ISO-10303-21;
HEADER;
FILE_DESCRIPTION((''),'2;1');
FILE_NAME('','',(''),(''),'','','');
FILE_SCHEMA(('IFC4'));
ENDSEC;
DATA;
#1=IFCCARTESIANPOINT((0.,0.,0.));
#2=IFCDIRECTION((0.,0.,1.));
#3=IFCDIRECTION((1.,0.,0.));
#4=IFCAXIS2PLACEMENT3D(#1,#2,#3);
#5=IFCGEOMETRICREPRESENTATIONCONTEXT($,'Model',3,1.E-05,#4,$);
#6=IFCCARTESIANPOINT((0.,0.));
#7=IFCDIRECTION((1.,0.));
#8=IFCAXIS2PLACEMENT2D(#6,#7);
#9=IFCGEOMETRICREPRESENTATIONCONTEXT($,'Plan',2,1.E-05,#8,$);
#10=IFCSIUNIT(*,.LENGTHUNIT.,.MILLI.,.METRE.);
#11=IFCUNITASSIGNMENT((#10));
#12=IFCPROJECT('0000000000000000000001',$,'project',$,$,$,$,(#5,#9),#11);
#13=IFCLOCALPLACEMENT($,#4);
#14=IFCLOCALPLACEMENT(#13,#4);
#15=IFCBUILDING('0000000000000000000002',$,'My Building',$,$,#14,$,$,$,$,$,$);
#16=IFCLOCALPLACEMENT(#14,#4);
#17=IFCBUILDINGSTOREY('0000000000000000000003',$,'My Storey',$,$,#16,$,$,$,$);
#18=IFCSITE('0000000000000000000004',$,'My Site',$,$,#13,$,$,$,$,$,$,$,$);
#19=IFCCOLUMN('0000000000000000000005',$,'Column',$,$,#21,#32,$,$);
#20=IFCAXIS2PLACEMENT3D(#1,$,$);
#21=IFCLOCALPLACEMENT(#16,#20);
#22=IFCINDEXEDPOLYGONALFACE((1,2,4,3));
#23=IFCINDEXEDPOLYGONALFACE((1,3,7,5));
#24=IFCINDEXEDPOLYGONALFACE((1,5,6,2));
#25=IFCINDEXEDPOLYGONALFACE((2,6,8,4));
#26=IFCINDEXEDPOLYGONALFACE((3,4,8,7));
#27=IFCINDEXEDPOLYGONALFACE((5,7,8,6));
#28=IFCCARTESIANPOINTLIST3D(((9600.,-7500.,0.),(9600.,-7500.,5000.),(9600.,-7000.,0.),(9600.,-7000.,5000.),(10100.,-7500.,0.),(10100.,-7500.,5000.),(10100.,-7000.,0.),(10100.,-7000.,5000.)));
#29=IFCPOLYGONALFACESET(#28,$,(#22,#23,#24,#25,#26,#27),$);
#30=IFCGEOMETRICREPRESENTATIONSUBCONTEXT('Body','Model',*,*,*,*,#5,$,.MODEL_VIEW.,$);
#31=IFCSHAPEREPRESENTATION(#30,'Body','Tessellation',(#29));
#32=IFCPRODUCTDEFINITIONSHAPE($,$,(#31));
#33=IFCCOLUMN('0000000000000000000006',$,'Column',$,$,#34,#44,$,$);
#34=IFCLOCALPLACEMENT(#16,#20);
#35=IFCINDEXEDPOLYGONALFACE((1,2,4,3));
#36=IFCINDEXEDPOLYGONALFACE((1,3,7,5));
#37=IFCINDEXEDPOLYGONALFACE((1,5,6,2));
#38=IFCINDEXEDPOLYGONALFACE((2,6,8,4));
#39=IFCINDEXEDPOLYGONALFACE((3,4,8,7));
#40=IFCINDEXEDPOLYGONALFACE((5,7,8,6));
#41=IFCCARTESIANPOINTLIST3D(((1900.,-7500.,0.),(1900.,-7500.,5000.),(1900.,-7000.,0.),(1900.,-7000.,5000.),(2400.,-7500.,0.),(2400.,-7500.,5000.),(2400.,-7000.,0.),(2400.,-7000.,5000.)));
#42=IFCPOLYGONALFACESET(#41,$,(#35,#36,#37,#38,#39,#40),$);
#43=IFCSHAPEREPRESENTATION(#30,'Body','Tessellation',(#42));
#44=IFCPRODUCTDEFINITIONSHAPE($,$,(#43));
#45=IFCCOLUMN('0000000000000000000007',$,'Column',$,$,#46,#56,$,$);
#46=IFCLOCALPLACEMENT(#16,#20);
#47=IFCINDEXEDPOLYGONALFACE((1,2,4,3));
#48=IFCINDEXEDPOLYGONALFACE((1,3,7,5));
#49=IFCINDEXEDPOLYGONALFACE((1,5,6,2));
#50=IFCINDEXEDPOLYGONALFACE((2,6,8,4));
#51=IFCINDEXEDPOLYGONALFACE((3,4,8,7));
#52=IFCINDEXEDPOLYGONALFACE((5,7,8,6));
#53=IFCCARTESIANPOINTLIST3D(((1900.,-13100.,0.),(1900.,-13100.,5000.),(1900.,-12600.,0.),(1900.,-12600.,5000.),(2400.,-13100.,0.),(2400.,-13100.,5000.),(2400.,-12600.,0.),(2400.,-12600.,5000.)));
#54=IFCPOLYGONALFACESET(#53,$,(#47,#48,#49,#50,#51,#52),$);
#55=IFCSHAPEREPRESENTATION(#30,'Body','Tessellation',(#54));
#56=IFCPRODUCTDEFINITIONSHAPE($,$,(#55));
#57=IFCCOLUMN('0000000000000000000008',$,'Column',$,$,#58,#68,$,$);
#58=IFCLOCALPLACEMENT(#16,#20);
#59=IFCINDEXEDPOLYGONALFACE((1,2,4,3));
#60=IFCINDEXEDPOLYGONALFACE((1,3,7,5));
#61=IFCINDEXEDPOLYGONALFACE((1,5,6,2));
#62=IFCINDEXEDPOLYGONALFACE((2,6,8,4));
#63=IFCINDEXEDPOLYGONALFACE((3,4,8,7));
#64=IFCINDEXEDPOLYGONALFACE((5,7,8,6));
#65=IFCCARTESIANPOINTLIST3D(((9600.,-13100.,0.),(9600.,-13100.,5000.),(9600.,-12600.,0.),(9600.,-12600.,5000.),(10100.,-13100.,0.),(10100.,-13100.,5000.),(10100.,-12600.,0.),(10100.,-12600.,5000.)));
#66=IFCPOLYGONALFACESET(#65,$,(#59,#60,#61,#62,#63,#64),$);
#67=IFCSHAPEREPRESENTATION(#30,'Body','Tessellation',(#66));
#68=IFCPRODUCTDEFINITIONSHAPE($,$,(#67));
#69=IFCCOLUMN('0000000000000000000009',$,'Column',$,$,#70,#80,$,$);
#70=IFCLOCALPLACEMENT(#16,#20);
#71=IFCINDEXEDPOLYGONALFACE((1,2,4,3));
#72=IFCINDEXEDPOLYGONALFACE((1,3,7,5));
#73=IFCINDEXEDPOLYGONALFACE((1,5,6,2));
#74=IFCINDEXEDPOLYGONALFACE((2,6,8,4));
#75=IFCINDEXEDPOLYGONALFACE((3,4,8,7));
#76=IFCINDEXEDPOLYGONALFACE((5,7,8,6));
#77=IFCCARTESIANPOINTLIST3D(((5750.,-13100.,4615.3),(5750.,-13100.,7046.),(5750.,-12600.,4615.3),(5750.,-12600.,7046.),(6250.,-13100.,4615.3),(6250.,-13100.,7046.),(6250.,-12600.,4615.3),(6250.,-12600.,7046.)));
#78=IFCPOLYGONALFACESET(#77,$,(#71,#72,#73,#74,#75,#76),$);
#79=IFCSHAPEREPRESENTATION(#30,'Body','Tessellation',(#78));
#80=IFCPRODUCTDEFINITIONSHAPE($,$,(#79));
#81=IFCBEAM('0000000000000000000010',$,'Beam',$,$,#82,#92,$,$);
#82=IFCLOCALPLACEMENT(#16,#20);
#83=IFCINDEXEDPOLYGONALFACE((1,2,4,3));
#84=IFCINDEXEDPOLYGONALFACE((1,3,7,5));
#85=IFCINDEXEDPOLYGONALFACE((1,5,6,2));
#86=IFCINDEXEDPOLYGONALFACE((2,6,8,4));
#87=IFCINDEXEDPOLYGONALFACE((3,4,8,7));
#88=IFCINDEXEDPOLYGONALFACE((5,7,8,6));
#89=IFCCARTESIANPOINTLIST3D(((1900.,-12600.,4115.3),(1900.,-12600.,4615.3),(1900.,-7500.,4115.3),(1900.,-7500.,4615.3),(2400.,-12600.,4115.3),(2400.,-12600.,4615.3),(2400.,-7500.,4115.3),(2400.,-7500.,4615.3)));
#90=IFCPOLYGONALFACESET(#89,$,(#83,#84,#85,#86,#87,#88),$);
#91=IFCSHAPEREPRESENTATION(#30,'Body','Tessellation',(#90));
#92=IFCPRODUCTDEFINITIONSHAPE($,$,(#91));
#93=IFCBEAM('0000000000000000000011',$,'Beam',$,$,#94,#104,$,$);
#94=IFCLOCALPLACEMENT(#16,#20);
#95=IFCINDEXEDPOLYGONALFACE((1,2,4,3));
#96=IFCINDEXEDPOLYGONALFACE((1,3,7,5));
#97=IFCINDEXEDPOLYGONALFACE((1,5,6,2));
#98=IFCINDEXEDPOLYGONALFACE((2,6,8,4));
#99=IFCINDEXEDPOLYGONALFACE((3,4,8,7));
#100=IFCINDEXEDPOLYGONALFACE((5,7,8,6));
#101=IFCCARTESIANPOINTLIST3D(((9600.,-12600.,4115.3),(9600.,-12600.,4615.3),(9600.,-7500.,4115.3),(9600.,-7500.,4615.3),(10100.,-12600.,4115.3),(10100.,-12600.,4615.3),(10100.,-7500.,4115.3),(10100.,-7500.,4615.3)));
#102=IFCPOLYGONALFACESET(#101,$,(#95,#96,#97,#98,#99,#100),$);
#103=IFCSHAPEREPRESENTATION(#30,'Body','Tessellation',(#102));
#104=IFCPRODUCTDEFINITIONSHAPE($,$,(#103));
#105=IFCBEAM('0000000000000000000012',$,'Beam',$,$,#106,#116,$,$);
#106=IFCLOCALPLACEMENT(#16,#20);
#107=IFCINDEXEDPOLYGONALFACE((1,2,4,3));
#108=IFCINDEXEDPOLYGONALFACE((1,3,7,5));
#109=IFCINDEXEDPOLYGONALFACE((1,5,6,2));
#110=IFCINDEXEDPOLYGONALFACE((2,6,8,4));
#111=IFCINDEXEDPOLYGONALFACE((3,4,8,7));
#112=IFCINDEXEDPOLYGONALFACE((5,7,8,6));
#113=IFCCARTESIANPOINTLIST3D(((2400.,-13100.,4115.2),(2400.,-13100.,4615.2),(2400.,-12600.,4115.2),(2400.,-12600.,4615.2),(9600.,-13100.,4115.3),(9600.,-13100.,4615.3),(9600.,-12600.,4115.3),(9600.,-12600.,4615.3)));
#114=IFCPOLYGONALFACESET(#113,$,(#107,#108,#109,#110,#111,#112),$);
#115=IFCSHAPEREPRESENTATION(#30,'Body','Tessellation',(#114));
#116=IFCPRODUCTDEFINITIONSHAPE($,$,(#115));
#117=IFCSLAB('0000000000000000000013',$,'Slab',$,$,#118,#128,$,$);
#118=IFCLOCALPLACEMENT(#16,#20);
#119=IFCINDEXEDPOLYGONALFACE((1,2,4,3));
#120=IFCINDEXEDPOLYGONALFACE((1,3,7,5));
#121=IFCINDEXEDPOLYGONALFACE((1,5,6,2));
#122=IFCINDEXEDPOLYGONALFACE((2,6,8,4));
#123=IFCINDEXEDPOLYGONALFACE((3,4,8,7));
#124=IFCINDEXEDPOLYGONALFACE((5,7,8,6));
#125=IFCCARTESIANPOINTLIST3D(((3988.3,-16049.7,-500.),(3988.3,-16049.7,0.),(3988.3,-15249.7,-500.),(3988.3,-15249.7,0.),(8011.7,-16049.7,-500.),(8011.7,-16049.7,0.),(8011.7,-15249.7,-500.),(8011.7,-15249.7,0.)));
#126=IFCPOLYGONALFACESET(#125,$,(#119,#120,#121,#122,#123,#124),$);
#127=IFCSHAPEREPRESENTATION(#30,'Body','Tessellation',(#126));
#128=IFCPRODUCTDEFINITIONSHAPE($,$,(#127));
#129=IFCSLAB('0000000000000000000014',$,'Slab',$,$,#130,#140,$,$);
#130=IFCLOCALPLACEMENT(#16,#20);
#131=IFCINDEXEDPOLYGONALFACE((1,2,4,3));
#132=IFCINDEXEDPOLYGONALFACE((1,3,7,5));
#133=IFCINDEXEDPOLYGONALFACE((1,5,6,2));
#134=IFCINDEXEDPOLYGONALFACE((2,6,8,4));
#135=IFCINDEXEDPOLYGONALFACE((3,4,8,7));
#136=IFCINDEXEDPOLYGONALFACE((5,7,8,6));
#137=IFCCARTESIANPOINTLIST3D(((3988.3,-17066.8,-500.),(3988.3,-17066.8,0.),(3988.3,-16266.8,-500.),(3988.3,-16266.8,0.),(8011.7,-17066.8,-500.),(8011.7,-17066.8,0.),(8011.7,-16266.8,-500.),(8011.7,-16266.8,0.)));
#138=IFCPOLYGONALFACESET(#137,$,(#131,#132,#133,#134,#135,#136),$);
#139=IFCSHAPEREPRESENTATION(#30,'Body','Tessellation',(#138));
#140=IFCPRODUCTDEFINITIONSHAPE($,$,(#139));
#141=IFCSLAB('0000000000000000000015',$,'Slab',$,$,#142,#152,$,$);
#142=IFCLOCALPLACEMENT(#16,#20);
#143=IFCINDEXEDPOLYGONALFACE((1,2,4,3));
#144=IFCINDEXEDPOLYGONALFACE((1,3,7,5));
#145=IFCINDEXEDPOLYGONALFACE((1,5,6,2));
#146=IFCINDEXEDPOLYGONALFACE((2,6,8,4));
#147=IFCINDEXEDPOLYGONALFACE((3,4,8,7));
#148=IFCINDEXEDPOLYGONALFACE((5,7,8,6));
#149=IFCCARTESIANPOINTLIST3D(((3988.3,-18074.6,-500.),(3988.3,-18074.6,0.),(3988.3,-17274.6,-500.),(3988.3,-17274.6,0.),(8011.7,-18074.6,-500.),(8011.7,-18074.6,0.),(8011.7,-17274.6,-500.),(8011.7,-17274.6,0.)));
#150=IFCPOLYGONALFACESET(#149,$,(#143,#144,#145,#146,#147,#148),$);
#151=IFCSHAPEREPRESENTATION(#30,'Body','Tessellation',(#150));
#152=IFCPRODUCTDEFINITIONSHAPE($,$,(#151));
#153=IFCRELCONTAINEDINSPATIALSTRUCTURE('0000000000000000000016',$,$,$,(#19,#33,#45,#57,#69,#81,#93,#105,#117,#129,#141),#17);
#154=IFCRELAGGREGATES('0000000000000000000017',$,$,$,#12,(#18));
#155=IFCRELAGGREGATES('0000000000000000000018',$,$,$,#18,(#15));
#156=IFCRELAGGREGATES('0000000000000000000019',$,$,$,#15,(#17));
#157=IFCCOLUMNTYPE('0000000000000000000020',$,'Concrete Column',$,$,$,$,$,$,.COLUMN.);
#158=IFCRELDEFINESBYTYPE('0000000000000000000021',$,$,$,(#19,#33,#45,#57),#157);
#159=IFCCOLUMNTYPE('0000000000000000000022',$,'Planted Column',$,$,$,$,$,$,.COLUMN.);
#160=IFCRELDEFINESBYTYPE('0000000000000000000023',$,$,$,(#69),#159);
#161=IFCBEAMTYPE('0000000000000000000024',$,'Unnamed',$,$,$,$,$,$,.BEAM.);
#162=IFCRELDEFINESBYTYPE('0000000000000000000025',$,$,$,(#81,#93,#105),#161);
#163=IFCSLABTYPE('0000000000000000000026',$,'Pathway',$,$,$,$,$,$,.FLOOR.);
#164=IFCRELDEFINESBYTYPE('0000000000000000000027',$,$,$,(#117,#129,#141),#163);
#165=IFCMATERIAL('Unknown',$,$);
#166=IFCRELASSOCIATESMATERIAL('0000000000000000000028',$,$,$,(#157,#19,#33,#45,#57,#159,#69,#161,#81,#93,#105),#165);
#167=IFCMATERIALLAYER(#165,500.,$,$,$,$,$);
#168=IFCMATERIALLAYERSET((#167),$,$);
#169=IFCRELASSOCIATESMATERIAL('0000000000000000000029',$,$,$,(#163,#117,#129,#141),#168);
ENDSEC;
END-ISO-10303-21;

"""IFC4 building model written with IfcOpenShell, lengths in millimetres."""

from ifc_helpers import new_model, si_unit, frame, origin_with_axes, origin_2d_with_axis, place, context, subcontext, project, spatial, indexed_curve, rectangle, outline, extrude, material, layer, layer_set, layer_usage, material_profile, profile_set, profile_usage, type_object, element, save


model = new_model("IFC4")

# Units and contexts
model_context = context("Model", 3, precision=1e-05, world=origin_with_axes())
plan_context = context("Plan", 2, precision=1e-05, world=origin_2d_with_axis())
body_context_1 = subcontext(model_context, "Body", "Model", "MODEL_VIEW")
ifc_project = project(units=[si_unit("LENGTHUNIT", "METRE", prefix="MILLI")], contexts=[model_context, plan_context])

# Site, building, storey
site_placement = place(None, origin_with_axes())
site = spatial("IfcSite", under=ifc_project, at=site_placement, Name="My Site")
building_placement = place(site_placement, origin_with_axes())
building = spatial("IfcBuilding", under=site, at=building_placement, Name="My Building")
storey_placement = place(building_placement, origin_with_axes())
storey = spatial("IfcBuildingStorey", under=building, at=storey_placement, Name="My Storey")

# Columns
ifc_material = material(Name="Unknown")
ifc_material_profile_1 = material_profile(ifc_material, rectangle(XDim=500.0, YDim=500.0))
ifc_profile_set_1 = profile_set([ifc_material_profile_1])
ifc_profile_usage_1 = profile_usage(ifc_profile_set_1, cardinal=1)
column_type_1 = type_object("IfcColumnType", Name="Concrete Column", PredefinedType="COLUMN", material=ifc_profile_set_1)
column_1_placement = place(storey_placement, frame((10100.0, -7500.0, 0.0), z_axis=(0.0, 0.0, 1.0), x_axis=(1.0, 0.0, 0.0)))
element("IfcColumn", 1, at=column_1_placement, inside=storey, type_object=column_type_1, material=ifc_profile_usage_1, Name="Column", context=body_context_1, shape_type="SweptSolid", body=[
    extrude(rectangle(XDim=500.0, YDim=500.0), frame((-250.0, 250.0, 0.0), z_axis=(0.0, 0.0, 1.0), x_axis=(1.0, 0.0, 0.0)), (0.0, 0.0, 1.0), 5000.0),
])
ifc_profile_usage_2 = profile_usage(ifc_profile_set_1, cardinal=1)
column_2_placement = place(storey_placement, frame((2400.0, -7500.0, 0.0), z_axis=(0.0, 0.0, 1.0), x_axis=(1.0, 0.0, 0.0)))
element("IfcColumn", 2, at=column_2_placement, inside=storey, type_object=column_type_1, material=ifc_profile_usage_2, Name="Column", context=body_context_1, shape_type="SweptSolid", body=[
    extrude(rectangle(XDim=500.0, YDim=500.0), frame((-250.0, 250.0, 0.0), z_axis=(0.0, 0.0, 1.0), x_axis=(1.0, 0.0, 0.0)), (0.0, 0.0, 1.0), 5000.0),
])
ifc_profile_usage_3 = profile_usage(ifc_profile_set_1, cardinal=9)
column_3_placement = place(storey_placement, frame((1900.0, -12600.0, 0.0), z_axis=(0.0, 0.0, 1.0), x_axis=(1.0, 0.0, 0.0)))
element("IfcColumn", 3, at=column_3_placement, inside=storey, type_object=column_type_1, material=ifc_profile_usage_3, Name="Column", context=body_context_1, shape_type="SweptSolid", body=[
    extrude(rectangle(XDim=500.0, YDim=500.0), frame((250.0, -250.0, 0.0), z_axis=(0.0, 0.0, 1.0), x_axis=(1.0, 0.0, 0.0)), (0.0, 0.0, 1.0), 5000.0),
])
ifc_profile_usage_4 = profile_usage(ifc_profile_set_1, cardinal=9)
column_4_placement = place(storey_placement, frame((9600.0, -12600.0, 0.0), z_axis=(0.0, 0.0, 1.0), x_axis=(1.0, 0.0, 0.0)))
element("IfcColumn", 4, at=column_4_placement, inside=storey, type_object=column_type_1, material=ifc_profile_usage_4, Name="Column", context=body_context_1, shape_type="SweptSolid", body=[
    extrude(rectangle(XDim=500.0, YDim=500.0), frame((250.0, -250.0, 0.0), z_axis=(0.0, 0.0, 1.0), x_axis=(1.0, 0.0, 0.0)), (0.0, 0.0, 1.0), 5000.0),
])
ifc_material_profile_2 = material_profile(ifc_material, rectangle(XDim=500.0, YDim=500.0))
ifc_profile_set_2 = profile_set([ifc_material_profile_2])
ifc_profile_usage_5 = profile_usage(ifc_profile_set_2, cardinal=5)
column_type_2 = type_object("IfcColumnType", Name="Planted Column", PredefinedType="COLUMN", material=ifc_profile_set_2)
column_5_placement = place(storey_placement, frame((6000.0, -12850.0, 4615.3), z_axis=(0.0, 0.0, 1.0), x_axis=(1.0, 0.0, 0.0)))
element("IfcColumn", 5, at=column_5_placement, inside=storey, type_object=column_type_2, material=ifc_profile_usage_5, Name="Column", context=body_context_1, shape_type="SweptSolid", body=[
    extrude(rectangle(XDim=500.0, YDim=500.0), origin_with_axes(), (0.0, 0.0, 1.0), 2430.7),
])

# Beams
ifc_material_profile_3 = material_profile(ifc_material, rectangle(XDim=500.0, YDim=500.0))
ifc_profile_set_3 = profile_set([ifc_material_profile_3])
ifc_profile_usage_6 = profile_usage(ifc_profile_set_3, cardinal=5)
beam_type = type_object("IfcBeamType", Name="Unnamed", PredefinedType="BEAM", material=ifc_profile_set_3)
beam_1_placement = place(storey_placement, frame((2150.0, -7500.0, 4365.3), z_axis=(0.0, -1.0, 0.0), x_axis=(1.0, 0.0, 0.0)))
element("IfcBeam", 6, at=beam_1_placement, inside=storey, type_object=beam_type, material=ifc_profile_usage_6, Name="Beam", context=body_context_1, shape_type="SweptSolid", body=[
    extrude(rectangle(XDim=500.0, YDim=500.0), origin_with_axes(), (0.0, 0.0, 1.0), 5100.0),
])
ifc_profile_usage_7 = profile_usage(ifc_profile_set_3, cardinal=5)
beam_2_placement = place(storey_placement, frame((9850.0, -7500.0, 4365.3), z_axis=(0.0, -1.0, 0.0), x_axis=(1.0, 0.0, 0.0)))
element("IfcBeam", 7, at=beam_2_placement, inside=storey, type_object=beam_type, material=ifc_profile_usage_7, Name="Beam", context=body_context_1, shape_type="SweptSolid", body=[
    extrude(rectangle(XDim=500.0, YDim=500.0), origin_with_axes(), (0.0, 0.0, 1.0), 5100.0),
])
ifc_profile_usage_8 = profile_usage(ifc_profile_set_3, cardinal=5)
beam_3_placement = place(storey_placement, frame((2400.0, -12850.0, 4365.2), z_axis=(1.0, 0.0, 0.0), x_axis=(0.0, 1.0, 0.0)))
element("IfcBeam", 8, at=beam_3_placement, inside=storey, type_object=beam_type, material=ifc_profile_usage_8, Name="Beam", context=body_context_1, shape_type="SweptSolid", body=[
    extrude(rectangle(XDim=500.0, YDim=500.0), origin_with_axes(), (0.0, 0.0, 1.0), 7200.0),
])

# Slabs
ifc_layer_1 = layer(ifc_material, 500.0)
ifc_layer_set_1 = layer_set([ifc_layer_1])
ifc_layer_usage_1 = layer_usage(ifc_layer_set_1, "AXIS3", "POSITIVE", -500.0)
slab_type = type_object("IfcSlabType", Name="Pathway", PredefinedType="FLOOR", material=ifc_layer_set_1)
slab_1_placement = place(storey_placement, frame((3988.3, -15249.7, 0.0), z_axis=(0.0, 0.0, 1.0), x_axis=(1.0, 0.0, 0.0)))
element("IfcSlab", 9, at=slab_1_placement, inside=storey, type_object=slab_type, material=ifc_layer_usage_1, Name="Slab", context=body_context_1, shape_type="SweptSolid", body=[
    extrude(outline(indexed_curve([(0.0, 0.0), (4023.4, 0.0), (4023.4, -800.0), (0.0, -800.0), (0.0, 0.0)])), frame((0.0, 0.0, -500.0), z_axis=(0.0, 0.0, 1.0), x_axis=(1.0, 0.0, 0.0)), (0.0, 0.0, 1.0), 500.0),
])
ifc_layer_usage_2 = layer_usage(ifc_layer_set_1, "AXIS3", "POSITIVE", -500.0)
slab_2_placement = place(storey_placement, frame((3988.3, -16266.8, 0.0), z_axis=(0.0, 0.0, 1.0), x_axis=(1.0, 0.0, 0.0)))
element("IfcSlab", 10, at=slab_2_placement, inside=storey, type_object=slab_type, material=ifc_layer_usage_2, Name="Slab", context=body_context_1, shape_type="SweptSolid", body=[
    extrude(outline(indexed_curve([(0.0, 0.0), (4023.4, 0.0), (4023.4, -800.0), (0.0, -800.0), (0.0, 0.0)])), frame((0.0, 0.0, -500.0), z_axis=(0.0, 0.0, 1.0), x_axis=(1.0, 0.0, 0.0)), (0.0, 0.0, 1.0), 500.0),
])
ifc_layer_usage_3 = layer_usage(ifc_layer_set_1, "AXIS3", "POSITIVE", -500.0)
slab_3_placement = place(storey_placement, frame((3988.3, -17274.6, 0.0), z_axis=(0.0, 0.0, 1.0), x_axis=(1.0, 0.0, 0.0)))
element("IfcSlab", 11, at=slab_3_placement, inside=storey, type_object=slab_type, material=ifc_layer_usage_3, Name="Slab", context=body_context_1, shape_type="SweptSolid", body=[
    extrude(outline(indexed_curve([(0.0, 0.0), (4023.4, 0.0), (4023.4, -800.0), (0.0, -800.0), (0.0, 0.0)])), frame((0.0, 0.0, -500.0), z_axis=(0.0, 0.0, 1.0), x_axis=(1.0, 0.0, 0.0)), (0.0, 0.0, 1.0), 500.0),
])

save(model, "model.ifc")
